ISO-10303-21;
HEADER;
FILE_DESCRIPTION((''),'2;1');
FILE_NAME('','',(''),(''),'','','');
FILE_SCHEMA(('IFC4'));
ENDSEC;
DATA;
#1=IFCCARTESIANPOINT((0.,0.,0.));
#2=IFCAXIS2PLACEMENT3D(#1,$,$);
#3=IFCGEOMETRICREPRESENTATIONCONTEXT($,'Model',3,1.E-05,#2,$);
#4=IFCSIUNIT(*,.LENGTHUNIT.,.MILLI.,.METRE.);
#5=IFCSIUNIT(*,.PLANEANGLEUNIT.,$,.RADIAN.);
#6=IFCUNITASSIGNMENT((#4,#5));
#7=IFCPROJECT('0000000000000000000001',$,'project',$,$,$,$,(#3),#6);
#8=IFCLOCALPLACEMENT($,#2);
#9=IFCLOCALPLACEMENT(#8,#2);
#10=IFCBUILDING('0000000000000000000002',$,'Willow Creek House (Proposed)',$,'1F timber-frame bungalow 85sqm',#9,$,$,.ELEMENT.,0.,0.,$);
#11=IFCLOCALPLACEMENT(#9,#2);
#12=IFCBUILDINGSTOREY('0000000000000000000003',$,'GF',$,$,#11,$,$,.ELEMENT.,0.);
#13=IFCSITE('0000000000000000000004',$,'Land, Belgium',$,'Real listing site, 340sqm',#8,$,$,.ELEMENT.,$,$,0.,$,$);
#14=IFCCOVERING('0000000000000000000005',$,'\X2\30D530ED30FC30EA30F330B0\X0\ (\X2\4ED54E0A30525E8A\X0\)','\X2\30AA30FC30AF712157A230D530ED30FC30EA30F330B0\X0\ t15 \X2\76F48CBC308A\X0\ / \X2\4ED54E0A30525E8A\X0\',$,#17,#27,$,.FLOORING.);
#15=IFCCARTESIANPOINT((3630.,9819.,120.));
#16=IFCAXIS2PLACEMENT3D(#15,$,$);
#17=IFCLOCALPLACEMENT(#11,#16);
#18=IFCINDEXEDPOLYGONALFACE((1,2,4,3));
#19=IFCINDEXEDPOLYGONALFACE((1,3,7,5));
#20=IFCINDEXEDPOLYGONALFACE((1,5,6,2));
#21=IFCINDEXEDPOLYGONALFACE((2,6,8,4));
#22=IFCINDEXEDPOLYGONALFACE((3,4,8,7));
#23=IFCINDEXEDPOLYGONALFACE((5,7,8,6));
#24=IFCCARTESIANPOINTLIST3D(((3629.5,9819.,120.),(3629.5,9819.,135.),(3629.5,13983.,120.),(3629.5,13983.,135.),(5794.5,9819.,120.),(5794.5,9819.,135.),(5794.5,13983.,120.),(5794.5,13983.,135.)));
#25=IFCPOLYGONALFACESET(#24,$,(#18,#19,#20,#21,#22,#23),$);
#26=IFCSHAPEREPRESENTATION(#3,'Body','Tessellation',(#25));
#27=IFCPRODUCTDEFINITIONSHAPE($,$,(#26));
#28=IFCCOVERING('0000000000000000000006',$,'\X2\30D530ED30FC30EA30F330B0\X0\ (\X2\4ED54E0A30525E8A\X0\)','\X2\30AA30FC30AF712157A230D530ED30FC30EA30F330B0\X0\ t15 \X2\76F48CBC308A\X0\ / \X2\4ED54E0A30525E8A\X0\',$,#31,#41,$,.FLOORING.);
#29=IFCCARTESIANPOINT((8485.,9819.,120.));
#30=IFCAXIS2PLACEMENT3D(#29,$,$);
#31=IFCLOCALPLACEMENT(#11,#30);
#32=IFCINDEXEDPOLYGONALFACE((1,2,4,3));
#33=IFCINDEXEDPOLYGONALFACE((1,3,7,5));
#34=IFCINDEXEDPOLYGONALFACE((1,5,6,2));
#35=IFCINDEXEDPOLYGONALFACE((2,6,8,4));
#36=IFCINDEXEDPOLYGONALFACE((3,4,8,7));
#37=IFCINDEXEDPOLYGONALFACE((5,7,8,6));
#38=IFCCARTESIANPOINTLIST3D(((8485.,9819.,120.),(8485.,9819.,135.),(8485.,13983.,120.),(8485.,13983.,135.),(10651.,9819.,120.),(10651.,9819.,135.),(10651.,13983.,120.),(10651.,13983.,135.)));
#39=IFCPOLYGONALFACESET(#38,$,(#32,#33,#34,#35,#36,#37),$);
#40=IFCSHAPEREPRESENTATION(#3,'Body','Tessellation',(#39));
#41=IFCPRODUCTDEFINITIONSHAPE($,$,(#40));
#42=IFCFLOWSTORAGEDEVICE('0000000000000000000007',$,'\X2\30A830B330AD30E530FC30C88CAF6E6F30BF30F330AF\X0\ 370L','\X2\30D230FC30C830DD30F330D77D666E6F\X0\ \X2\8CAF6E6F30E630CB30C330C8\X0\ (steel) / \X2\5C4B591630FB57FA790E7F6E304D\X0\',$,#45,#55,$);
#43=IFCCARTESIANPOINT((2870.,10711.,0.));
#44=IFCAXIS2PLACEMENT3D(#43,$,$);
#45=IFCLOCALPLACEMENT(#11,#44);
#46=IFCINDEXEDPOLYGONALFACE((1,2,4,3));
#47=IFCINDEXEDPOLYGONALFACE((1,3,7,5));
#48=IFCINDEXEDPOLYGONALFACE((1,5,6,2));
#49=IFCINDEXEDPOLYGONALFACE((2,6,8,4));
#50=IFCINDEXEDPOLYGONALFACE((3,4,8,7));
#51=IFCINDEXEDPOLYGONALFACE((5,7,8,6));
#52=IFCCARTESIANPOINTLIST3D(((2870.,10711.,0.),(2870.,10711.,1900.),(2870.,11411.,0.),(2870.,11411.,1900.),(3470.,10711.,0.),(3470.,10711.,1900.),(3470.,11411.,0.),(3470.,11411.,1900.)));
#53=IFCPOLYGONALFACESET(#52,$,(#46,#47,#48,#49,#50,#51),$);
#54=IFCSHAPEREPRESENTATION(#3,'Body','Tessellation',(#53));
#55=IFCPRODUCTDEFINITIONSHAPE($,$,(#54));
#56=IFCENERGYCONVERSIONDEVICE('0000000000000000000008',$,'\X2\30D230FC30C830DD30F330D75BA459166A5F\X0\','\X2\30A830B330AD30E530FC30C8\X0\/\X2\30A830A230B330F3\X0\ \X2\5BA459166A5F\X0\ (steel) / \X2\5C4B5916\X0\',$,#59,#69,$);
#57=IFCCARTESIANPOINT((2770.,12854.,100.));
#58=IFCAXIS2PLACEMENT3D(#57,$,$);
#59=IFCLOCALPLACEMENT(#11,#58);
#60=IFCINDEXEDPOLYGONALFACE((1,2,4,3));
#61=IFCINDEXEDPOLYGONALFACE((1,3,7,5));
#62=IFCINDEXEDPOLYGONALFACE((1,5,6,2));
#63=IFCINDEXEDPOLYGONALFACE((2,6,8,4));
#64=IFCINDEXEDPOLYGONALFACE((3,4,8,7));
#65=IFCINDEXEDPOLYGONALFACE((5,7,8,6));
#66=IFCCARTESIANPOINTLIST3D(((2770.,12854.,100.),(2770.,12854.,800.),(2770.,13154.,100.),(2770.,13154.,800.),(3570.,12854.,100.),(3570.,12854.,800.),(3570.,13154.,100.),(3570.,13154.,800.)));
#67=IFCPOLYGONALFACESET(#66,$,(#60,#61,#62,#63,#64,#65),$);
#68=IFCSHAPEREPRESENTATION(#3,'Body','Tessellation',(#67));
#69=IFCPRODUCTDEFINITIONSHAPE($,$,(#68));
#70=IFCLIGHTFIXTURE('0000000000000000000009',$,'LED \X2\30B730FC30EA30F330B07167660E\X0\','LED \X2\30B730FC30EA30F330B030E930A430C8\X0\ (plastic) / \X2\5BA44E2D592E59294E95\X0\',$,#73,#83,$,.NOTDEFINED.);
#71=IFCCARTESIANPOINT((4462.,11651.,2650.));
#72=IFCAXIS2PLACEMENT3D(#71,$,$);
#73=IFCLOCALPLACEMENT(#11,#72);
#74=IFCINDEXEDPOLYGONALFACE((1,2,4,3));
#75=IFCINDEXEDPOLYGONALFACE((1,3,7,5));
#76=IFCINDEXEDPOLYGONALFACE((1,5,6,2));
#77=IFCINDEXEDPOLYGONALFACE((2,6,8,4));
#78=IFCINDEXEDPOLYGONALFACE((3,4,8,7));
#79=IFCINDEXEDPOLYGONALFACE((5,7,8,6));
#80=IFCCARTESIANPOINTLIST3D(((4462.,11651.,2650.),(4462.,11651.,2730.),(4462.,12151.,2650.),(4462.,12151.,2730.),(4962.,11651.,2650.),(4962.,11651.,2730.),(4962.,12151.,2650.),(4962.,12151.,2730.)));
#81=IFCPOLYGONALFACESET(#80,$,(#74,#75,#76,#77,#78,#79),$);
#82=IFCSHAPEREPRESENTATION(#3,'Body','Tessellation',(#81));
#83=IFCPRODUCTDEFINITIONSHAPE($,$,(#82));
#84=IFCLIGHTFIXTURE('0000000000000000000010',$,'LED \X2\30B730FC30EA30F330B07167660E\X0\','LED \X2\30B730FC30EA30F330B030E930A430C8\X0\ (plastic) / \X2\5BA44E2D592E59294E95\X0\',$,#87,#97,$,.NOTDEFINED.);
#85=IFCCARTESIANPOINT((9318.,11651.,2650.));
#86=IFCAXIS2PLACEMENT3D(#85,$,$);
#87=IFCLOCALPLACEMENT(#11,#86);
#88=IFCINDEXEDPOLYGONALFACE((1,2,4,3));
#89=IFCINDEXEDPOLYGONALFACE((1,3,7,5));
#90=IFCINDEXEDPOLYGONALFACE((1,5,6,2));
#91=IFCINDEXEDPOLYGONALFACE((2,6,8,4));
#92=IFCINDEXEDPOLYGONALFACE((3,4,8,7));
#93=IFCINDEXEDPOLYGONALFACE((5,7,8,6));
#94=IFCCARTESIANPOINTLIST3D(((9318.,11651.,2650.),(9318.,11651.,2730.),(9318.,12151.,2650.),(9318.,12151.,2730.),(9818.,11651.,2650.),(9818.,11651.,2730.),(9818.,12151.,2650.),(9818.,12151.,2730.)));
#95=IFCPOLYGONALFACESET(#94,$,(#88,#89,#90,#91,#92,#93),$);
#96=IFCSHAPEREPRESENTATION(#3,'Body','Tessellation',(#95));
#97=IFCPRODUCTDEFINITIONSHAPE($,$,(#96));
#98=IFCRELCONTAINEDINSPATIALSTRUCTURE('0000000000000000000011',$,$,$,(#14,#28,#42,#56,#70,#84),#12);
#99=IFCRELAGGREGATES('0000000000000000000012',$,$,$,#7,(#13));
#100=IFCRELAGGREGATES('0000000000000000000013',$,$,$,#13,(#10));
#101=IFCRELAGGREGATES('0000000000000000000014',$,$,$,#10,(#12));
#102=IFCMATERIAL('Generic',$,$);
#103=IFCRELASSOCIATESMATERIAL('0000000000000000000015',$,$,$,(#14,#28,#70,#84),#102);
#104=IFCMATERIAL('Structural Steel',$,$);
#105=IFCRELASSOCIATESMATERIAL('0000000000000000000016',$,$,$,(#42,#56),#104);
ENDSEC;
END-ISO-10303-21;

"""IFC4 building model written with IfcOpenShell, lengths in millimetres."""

from ifc_helpers import new_model, si_unit, frame, frame_2d, origin, place, context, project, spatial, rectangle, extrude, material, element, save


model = new_model("IFC4")

# Units and contexts
model_context = context("Model", 3, precision=1e-05, world=origin())
ifc_project = project(units=[si_unit("LENGTHUNIT", "METRE", prefix="MILLI"), si_unit("PLANEANGLEUNIT", "RADIAN")], contexts=[model_context])

# Site, building, storey
site_placement = place(None, origin())
site = spatial("IfcSite", under=ifc_project, at=site_placement, Name="Land, Belgium", ObjectType="Real listing site, 340sqm", CompositionType="ELEMENT", RefElevation=0.0)
building_placement = place(site_placement, origin())
building = spatial("IfcBuilding", under=site, at=building_placement, Name="Willow Creek House (Proposed)", ObjectType="1F timber-frame bungalow 85sqm", CompositionType="ELEMENT", ElevationOfRefHeight=0.0, ElevationOfTerrain=0.0)
storey_placement = place(building_placement, origin())
storey = spatial("IfcBuildingStorey", under=building, at=storey_placement, Name="GF", CompositionType="ELEMENT", Elevation=0.0)

# Shared definitions
ifc_material_1 = material(Name="Structural Steel")

# Coverings
ifc_material_2 = material(Name="Generic")
covering_1_placement = place(storey_placement, frame((3630.0, 9819.0, 120.0)))
element("IfcCovering", 1, at=covering_1_placement, inside=storey, material=ifc_material_2, Name="フローリング (仕上げ床)", Description="オーク無垢フローリング t15 直貼り / 仕上げ床", PredefinedType="FLOORING", context=model_context, shape_type="SweptSolid", body=[
    extrude(rectangle(XDim=2165.0, YDim=4164.0, at=frame_2d((1082.0, 2082.0))), frame((3630.0, 9819.0, 120.0)), (0.0, 0.0, 1.0), 15.0),
])
covering_2_placement = place(storey_placement, frame((8485.0, 9819.0, 120.0)))
element("IfcCovering", 2, at=covering_2_placement, inside=storey, material=ifc_material_2, Name="フローリング (仕上げ床)", Description="オーク無垢フローリング t15 直貼り / 仕上げ床", PredefinedType="FLOORING", context=model_context, shape_type="SweptSolid", body=[
    extrude(rectangle(XDim=2166.0, YDim=4164.0, at=frame_2d((1083.0, 2082.0))), frame((8485.0, 9819.0, 120.0)), (0.0, 0.0, 1.0), 15.0),
])

# Flow storage device
flow_storage_device_placement = place(storey_placement, frame((2870.0, 10711.0, 0.0)))
element("IfcFlowStorageDevice", 3, at=flow_storage_device_placement, inside=storey, material=ifc_material_1, Name="エコキュート貯湯タンク 370L", Description="ヒートポンプ給湯 貯湯ユニット (steel) / 屋外・基礎置き", context=model_context, shape_type="SweptSolid", body=[
    extrude(rectangle(XDim=600.0, YDim=700.0, at=frame_2d((300.0, 350.0))), frame((2870.0, 10711.0, 0.0)), (0.0, 0.0, 1.0), 1900.0),
])

# Energy conversion device
energy_conversion_device_placement = place(storey_placement, frame((2770.0, 12854.0, 100.0)))
element("IfcEnergyConversionDevice", 4, at=energy_conversion_device_placement, inside=storey, material=ifc_material_1, Name="ヒートポンプ室外機", Description="エコキュート/エアコン 室外機 (steel) / 屋外", context=model_context, shape_type="SweptSolid", body=[
    extrude(rectangle(XDim=800.0, YDim=300.0, at=frame_2d((400.0, 150.0))), frame((2770.0, 12854.0, 100.0)), (0.0, 0.0, 1.0), 700.0),
])

# Light fixtures
light_fixture_1_placement = place(storey_placement, frame((4462.0, 11651.0, 2650.0)))
element("IfcLightFixture", 5, at=light_fixture_1_placement, inside=storey, material=ifc_material_2, Name="LED シーリング照明", Description="LED シーリングライト (plastic) / 室中央天井", PredefinedType="NOTDEFINED", context=model_context, shape_type="SweptSolid", body=[
    extrude(rectangle(XDim=500.0, YDim=500.0, at=frame_2d((250.0, 250.0))), frame((4462.0, 11651.0, 2650.0)), (0.0, 0.0, 1.0), 80.0),
])
light_fixture_2_placement = place(storey_placement, frame((9318.0, 11651.0, 2650.0)))
element("IfcLightFixture", 6, at=light_fixture_2_placement, inside=storey, material=ifc_material_2, Name="LED シーリング照明", Description="LED シーリングライト (plastic) / 室中央天井", PredefinedType="NOTDEFINED", context=model_context, shape_type="SweptSolid", body=[
    extrude(rectangle(XDim=500.0, YDim=500.0, at=frame_2d((250.0, 250.0))), frame((9318.0, 11651.0, 2650.0)), (0.0, 0.0, 1.0), 80.0),
])

save(model, "model.ifc")
